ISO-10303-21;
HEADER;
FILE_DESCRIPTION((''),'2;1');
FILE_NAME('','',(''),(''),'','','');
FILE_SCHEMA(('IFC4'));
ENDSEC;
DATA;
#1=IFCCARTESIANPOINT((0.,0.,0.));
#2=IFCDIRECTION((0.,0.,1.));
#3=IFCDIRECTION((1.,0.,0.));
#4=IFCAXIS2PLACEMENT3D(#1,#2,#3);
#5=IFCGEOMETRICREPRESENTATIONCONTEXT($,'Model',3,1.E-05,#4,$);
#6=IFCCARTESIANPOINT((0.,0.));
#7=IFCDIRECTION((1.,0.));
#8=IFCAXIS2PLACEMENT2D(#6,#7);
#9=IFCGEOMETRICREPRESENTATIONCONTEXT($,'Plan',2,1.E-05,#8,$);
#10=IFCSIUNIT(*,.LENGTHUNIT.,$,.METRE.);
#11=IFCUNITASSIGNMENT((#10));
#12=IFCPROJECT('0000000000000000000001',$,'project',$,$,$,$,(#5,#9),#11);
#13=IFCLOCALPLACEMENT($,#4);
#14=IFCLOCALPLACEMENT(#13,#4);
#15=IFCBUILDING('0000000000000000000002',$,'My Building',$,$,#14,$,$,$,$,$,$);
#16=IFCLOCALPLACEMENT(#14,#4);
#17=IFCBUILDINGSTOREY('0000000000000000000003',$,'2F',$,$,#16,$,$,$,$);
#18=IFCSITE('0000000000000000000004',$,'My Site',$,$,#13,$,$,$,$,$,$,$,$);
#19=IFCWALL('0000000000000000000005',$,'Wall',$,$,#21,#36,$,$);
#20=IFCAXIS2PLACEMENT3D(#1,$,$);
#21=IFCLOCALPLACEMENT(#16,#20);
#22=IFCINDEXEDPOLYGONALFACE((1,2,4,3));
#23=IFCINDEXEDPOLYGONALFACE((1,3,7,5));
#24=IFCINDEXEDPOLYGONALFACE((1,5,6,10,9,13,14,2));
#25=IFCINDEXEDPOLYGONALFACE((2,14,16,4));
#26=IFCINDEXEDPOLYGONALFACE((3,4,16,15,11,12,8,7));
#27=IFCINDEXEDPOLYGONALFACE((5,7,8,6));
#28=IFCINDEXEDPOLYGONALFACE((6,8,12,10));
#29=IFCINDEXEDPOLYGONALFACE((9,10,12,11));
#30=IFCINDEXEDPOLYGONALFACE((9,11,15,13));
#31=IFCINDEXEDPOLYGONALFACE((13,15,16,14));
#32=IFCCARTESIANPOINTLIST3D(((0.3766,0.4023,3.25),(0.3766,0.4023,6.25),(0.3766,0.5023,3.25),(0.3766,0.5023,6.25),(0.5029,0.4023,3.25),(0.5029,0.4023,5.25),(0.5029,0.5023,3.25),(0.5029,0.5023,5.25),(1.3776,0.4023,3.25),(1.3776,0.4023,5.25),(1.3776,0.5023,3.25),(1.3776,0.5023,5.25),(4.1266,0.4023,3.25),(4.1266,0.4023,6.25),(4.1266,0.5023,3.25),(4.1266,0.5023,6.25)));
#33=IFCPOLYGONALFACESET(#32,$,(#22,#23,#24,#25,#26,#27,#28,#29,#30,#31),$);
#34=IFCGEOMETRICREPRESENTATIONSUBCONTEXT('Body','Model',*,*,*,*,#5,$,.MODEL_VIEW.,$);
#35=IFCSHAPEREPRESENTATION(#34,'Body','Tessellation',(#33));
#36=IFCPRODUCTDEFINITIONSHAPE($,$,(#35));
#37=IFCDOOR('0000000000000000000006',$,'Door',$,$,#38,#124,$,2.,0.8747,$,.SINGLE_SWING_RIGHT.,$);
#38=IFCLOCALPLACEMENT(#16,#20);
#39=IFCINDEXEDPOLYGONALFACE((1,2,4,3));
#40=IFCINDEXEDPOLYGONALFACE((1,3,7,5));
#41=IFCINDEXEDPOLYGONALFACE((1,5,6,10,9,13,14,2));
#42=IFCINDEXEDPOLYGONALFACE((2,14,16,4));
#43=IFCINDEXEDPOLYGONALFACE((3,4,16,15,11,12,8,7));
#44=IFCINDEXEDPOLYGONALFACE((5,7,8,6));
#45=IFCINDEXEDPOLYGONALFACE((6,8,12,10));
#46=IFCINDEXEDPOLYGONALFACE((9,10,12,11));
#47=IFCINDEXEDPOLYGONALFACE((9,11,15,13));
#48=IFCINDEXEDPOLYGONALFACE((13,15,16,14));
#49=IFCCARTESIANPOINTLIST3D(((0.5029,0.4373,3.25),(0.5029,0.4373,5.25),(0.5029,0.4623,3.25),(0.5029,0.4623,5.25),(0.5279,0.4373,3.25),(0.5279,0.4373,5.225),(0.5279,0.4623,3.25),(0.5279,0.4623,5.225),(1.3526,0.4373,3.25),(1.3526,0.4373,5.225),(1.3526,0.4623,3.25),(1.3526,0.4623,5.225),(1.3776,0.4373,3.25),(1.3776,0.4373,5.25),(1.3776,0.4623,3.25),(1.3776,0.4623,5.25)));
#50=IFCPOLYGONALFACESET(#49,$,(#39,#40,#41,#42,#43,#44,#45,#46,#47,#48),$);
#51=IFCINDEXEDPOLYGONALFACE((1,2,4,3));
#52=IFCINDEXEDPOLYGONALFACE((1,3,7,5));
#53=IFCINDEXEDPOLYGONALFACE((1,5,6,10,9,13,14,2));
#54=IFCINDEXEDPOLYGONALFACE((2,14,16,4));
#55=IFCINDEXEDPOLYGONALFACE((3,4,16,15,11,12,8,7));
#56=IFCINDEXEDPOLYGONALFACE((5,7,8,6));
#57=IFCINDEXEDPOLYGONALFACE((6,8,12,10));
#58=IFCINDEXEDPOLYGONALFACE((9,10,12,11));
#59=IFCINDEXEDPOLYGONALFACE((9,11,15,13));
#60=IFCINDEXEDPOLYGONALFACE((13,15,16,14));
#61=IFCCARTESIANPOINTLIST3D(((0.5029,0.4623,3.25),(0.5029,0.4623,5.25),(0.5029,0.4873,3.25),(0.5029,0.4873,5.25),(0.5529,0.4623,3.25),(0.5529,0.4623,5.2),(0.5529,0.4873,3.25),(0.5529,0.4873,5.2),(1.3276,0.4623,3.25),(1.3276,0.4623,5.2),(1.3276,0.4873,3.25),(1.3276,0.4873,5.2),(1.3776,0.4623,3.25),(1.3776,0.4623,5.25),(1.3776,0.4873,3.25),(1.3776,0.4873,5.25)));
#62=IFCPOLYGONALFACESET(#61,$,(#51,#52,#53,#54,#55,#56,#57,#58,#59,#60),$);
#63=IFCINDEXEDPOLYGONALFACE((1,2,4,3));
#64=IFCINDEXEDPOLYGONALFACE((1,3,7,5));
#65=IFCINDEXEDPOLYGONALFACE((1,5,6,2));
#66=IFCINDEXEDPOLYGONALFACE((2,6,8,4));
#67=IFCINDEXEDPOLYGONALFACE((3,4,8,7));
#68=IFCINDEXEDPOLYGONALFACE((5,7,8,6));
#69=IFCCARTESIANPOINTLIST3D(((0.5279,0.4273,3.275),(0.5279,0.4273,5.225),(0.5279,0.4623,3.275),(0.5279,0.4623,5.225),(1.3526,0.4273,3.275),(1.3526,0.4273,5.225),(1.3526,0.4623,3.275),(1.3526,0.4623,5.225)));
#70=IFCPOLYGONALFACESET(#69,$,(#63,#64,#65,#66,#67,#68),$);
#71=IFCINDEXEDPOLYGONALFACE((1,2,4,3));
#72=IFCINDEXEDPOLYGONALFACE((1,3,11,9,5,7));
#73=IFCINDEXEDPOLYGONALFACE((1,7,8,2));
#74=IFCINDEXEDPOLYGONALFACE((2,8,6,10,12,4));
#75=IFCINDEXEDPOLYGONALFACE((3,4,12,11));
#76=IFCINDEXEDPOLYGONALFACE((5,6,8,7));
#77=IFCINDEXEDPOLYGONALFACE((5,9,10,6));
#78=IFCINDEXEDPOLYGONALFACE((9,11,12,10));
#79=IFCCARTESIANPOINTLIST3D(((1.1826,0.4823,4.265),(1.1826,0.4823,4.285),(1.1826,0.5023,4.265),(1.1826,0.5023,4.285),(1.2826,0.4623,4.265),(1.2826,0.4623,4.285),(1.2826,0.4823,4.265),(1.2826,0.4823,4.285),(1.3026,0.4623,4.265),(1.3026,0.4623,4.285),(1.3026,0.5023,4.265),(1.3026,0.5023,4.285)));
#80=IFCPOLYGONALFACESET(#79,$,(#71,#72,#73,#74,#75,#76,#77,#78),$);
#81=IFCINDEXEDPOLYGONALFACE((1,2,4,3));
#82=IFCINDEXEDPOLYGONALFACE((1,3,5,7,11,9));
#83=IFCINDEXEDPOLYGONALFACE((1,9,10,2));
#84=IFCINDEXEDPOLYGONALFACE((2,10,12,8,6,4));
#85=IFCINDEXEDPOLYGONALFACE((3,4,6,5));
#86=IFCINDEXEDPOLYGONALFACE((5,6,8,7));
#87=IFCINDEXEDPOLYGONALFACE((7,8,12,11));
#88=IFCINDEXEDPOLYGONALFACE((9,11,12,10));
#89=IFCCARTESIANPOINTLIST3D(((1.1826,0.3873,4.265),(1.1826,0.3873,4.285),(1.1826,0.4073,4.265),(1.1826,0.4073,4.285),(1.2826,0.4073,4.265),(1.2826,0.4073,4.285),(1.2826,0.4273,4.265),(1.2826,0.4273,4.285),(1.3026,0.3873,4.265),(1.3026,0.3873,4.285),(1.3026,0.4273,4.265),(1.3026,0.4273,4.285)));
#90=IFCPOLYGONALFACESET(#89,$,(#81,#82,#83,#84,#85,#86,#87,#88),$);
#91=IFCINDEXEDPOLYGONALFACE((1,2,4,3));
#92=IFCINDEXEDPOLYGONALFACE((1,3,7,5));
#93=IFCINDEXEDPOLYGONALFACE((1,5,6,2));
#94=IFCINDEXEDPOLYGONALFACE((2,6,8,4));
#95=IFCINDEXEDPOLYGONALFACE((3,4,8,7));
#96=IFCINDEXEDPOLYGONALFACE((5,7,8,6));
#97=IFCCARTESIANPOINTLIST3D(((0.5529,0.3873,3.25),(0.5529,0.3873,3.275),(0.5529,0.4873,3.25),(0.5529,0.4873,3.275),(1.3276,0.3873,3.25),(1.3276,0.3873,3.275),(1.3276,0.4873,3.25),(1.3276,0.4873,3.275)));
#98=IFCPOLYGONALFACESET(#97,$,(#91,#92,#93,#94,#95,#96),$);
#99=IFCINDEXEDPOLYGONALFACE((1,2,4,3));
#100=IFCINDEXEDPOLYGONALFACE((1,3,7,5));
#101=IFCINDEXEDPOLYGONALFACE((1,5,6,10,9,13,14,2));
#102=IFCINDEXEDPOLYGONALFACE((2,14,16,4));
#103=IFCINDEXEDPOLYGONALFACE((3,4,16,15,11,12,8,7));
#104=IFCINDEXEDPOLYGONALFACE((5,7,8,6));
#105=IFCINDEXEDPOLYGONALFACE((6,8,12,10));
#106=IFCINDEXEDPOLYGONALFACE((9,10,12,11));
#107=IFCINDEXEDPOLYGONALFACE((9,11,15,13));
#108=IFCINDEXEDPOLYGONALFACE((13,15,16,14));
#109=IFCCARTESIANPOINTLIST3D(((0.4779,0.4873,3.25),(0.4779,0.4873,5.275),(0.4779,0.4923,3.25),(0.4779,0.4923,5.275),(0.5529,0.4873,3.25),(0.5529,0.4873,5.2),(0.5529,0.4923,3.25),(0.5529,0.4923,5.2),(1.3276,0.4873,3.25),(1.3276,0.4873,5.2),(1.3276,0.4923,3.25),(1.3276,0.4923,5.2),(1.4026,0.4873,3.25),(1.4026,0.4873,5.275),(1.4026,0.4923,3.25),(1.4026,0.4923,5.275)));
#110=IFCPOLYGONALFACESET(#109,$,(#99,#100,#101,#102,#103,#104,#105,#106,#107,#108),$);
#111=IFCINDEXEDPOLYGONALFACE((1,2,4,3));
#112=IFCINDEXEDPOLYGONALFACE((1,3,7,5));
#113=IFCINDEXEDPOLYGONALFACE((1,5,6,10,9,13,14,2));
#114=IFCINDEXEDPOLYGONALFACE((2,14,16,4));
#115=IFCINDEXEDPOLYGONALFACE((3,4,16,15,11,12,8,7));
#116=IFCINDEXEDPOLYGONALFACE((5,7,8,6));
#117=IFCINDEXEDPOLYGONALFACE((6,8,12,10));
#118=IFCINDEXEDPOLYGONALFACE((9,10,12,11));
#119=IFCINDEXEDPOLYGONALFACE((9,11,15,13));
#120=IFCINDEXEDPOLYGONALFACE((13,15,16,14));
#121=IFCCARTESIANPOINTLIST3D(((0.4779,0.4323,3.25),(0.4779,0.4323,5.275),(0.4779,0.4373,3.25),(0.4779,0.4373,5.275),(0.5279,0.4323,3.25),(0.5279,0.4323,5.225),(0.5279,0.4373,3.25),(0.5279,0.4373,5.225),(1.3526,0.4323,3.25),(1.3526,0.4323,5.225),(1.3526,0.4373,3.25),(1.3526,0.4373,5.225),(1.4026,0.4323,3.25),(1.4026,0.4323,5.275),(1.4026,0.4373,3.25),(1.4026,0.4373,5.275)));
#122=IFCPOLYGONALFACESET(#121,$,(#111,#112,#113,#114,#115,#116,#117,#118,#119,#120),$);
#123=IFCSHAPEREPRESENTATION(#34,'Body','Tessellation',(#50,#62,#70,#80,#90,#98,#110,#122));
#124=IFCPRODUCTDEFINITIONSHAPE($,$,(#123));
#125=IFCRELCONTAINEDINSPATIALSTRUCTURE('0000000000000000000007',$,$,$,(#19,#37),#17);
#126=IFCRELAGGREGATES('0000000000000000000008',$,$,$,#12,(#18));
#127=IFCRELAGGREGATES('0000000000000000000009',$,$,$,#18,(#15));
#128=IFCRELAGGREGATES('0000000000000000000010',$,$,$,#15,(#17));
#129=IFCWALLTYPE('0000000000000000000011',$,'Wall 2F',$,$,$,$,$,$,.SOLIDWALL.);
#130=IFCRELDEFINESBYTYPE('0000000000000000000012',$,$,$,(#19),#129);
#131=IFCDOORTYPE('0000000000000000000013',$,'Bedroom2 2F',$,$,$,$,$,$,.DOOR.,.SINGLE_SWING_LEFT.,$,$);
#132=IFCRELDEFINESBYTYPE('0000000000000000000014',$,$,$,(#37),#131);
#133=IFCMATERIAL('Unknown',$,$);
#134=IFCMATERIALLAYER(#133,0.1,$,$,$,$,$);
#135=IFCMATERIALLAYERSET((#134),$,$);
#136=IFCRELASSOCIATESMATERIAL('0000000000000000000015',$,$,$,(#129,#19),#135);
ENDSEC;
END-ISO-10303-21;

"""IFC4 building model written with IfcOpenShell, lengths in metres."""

from ifc_helpers import new_model, entity, si_unit, frame, origin_with_axes, origin_2d_with_axis, place, context, subcontext, project, spatial, line, indexed_curve, outline, extrude, shape, source, transform, mapped, material, layer, layer_set, layer_usage, type_object, type_shapes, element, fill, save


model = new_model("IFC4")

# Units and contexts
model_context = context("Model", 3, precision=1e-05, world=origin_with_axes())
plan_context = context("Plan", 2, precision=1e-05, world=origin_2d_with_axis())
body_context_1 = subcontext(model_context, "Body", "Model", "MODEL_VIEW")
body_context_2 = subcontext(plan_context, "Body", "Plan", "PLAN_VIEW")
ifc_project = project(units=[si_unit("LENGTHUNIT", "METRE")], contexts=[model_context, plan_context])

# Site, building, storey
site_placement = place(None, origin_with_axes())
site = spatial("IfcSite", under=ifc_project, at=site_placement, Name="My Site")
building_placement = place(site_placement, origin_with_axes())
building = spatial("IfcBuilding", under=site, at=building_placement, Name="My Building")
storey_placement = place(building_placement, origin_with_axes())
storey = spatial("IfcBuildingStorey", under=building, at=storey_placement, Name="2F")

# Shared definitions
ifc_material = material(Name="Unknown")

# Shared definitions
ifc_layer = layer(ifc_material, 0.1)
ifc_layer_set = layer_set([ifc_layer])
wall_type = type_object("IfcWallType", Name="Wall 2F", PredefinedType="SOLIDWALL", material=ifc_layer_set)

# Wall, opening, door
ifc_layer_usage_1 = layer_usage(ifc_layer_set, "AXIS2", "POSITIVE", 0.0)
wall_1_placement = place(storey_placement, frame((4.2266, 0.5023, 3.25), z_axis=(0.0, 0.0, 1.0), x_axis=(-1.0, 0.0, 0.0)))
wall_1 = element("IfcWall", 1, at=wall_1_placement, inside=storey, type_object=wall_type, material=ifc_layer_usage_1, Name="Wall", context=body_context_1, shape_type="SweptSolid", body=[
    extrude(outline(indexed_curve([(0.1, 0.0), (0.1, 0.1), (3.85, 0.1), (3.85, 0.0)], segments=[line(1, 2, 3, 4, 1)])), origin_with_axes(), (0.0, 0.0, 1.0), 3.0),
])
shared_shape_1 = source(origin_with_axes(), body_context_1, "Body", "SweptSolid", [
    extrude(outline(indexed_curve([(0.0, 0.0), (0.8747, 0.0), (0.8747, 2.0), (0.0, 2.0)], segments=[line(1, 2, 3, 4, 1)])), frame((0.0, -0.6, 0.0), z_axis=(0.0, -1.0, 0.0), x_axis=(1.0, 0.0, 0.0)), (0.0, 0.0, -1.0), 1.2),
])
opening_1_placement = place(wall_1_placement, frame((2.849, 0.015, 0.0), z_axis=(0.0, 0.0, 1.0), x_axis=(1.0, -0.000001, 0.0)))
opening_1 = element("IfcOpeningElement", 2, at=opening_1_placement, cuts=wall_1, PredefinedType="OPENING", context=body_context_1, shape_type="MappedRepresentation", body=[
    mapped(shared_shape_1, transform((0.0, 0.0, 0.0), x_axis=(1.0, 0.0, 0.0), y_axis=(0.0, 1.0, 0.0), z_axis=(0.0, 0.0, 1.0), scale=1.0)),
])
door_type_1 = type_object("IfcDoorType", Name="Bedroom2 2F", OperationType="SINGLE_SWING_LEFT", PredefinedType="DOOR")
shared_shape_2 = source(origin_with_axes(), body_context_1, "Body", "SweptSolid", [
    extrude(outline(indexed_curve([(0.0, 0.0), (0.0, 2.0), (0.8747, 2.0), (0.8747, 0.0), (0.8497, 0.0), (0.8497, 1.975), (0.025, 1.975), (0.025, 0.0)], segments=[line(1, 2, 3, 4, 5, 6, 7, 8, 1)])), frame((0.0, 0.025, 0.0), z_axis=(0.0, -1.0, 0.0), x_axis=(1.0, 0.0, 0.0)), (0.0, 0.0, -1.0), 0.025),
    extrude(outline(indexed_curve([(0.0, 0.0), (0.0, 2.0), (0.8747, 2.0), (0.8747, 0.0), (0.8247, 0.0), (0.8247, 1.95), (0.05, 1.95), (0.05, 0.0)], segments=[line(1, 2, 3, 4, 5, 6, 7, 8, 1)])), frame((0.0, 0.0, 0.0), z_axis=(0.0, -1.0, 0.0), x_axis=(1.0, 0.0, 0.0)), (0.0, 0.0, -1.0), 0.025),
    extrude(outline(indexed_curve([(0.0, 0.0), (0.8247, 0.0), (0.8247, 0.035), (0.0, 0.035)], segments=[line(1, 2, 3, 4, 1)])), frame((0.025, 0.025, 0.025), z_axis=(0.0, 0.0, 1.0), x_axis=(1.0, 0.0, 0.0)), (0.0, 0.0, 1.0), 1.95),
    extrude(outline(indexed_curve([(0.0, 0.0), (0.0, -0.04), (0.12, -0.04), (0.12, -0.02), (0.02, -0.02), (0.02, 0.0)], segments=[line(1, 2, 3, 4, 5, 6, 1)])), frame((0.075, 0.025, 1.015), z_axis=(0.0, 0.0, 1.0), x_axis=(1.0, 0.0, 0.0)), (0.0, 0.0, 1.0), 0.02),
    extrude(outline(indexed_curve([(0.0, 0.0), (0.0, 0.04), (0.12, 0.04), (0.12, 0.02), (0.02, 0.02), (0.02, 0.0)], segments=[line(1, 2, 3, 4, 5, 6, 1)])), frame((0.075, 0.06, 1.015), z_axis=(0.0, 0.0, 1.0), x_axis=(1.0, 0.0, 0.0)), (0.0, 0.0, 1.0), 0.02),
    extrude(outline(indexed_curve([(0.0, 0.0), (0.7747, 0.0), (0.7747, 0.1), (0.0, 0.1)], segments=[line(1, 2, 3, 4, 1)])), frame((0.05, 0.0, 0.0), z_axis=(0.0, 0.0, 1.0), x_axis=(1.0, 0.0, 0.0)), (0.0, 0.0, 1.0), 0.025),
    extrude(outline(indexed_curve([(0.0, 0.0), (0.0, 2.025), (0.9247, 2.025), (0.9247, 0.0), (0.8497, 0.0), (0.8497, 1.95), (0.075, 1.95), (0.075, 0.0)], segments=[line(1, 2, 3, 4, 5, 6, 7, 8, 1)])), frame((-0.025, -0.005, 0.0), z_axis=(0.0, -1.0, 0.0), x_axis=(1.0, 0.0, 0.0)), (0.0, 0.0, -1.0), 0.005),
    extrude(outline(indexed_curve([(0.0, 0.0), (0.0, 2.025), (0.9247, 2.025), (0.9247, 0.0), (0.8747, 0.0), (0.8747, 1.975), (0.05, 1.975), (0.05, 0.0)], segments=[line(1, 2, 3, 4, 5, 6, 7, 8, 1)])), frame((-0.025, 0.05, 0.0), z_axis=(0.0, -1.0, 0.0), x_axis=(1.0, 0.0, 0.0)), (0.0, 0.0, -1.0), 0.005),
])
shared_shape_3 = source(origin_with_axes(), body_context_2, "Body", "Curve2D", [
    entity("IfcIndexedPolyCurve", entity("IfcCartesianPointList2D", [[0.0, 0.0], [0.0, 0.05], [0.025, 0.05], [0.025, 0.025], [0.05, 0.025], [0.05, 0.0]]), [entity("IfcLineIndex", [1, 2, 3, 4, 5, 6, 1])]),
    entity("IfcIndexedPolyCurve", entity("IfcCartesianPointList2D", [[0.8747, 0.0], [0.8747, 0.05], [0.8497, 0.05], [0.8497, 0.025], [0.8247, 0.025], [0.8247, 0.0]]), [entity("IfcLineIndex", [1, 2, 3, 4, 5, 6, 1])]),
    entity("IfcTrimmedCurve", entity("IfcEllipse", entity("IfcAxis2Placement2D", entity("IfcCartesianPoint", [0.8147, 0.05]), entity("IfcDirection", [1.0, 0.0])), 0.7897, 0.8247), [entity("IfcCartesianPoint", [0.8147, 0.8747])], [entity("IfcCartesianPoint", [0.025, 0.05])], True, "CARTESIAN"),
    entity("IfcIndexedPolyCurve", entity("IfcCartesianPointList2D", [[0.8497, 0.05], [0.8147, 0.05], [0.8147, 0.8747], [0.8497, 0.8747]]), [entity("IfcLineIndex", [1, 2, 3, 4, 1])]),
])
type_shapes(door_type_1, [shared_shape_2, shared_shape_3])
door_1_placement = place(opening_1_placement, frame((0.0, 0.0, 0.0), z_axis=(0.0, 0.0, 1.0), x_axis=(1.0, 0.0, 0.0)))
door_1 = element("IfcDoor", 3, at=door_1_placement, inside=storey, type_object=door_type_1, Name="Door", OperationType="SINGLE_SWING_RIGHT", OverallHeight=2.0, OverallWidth=0.8747, shapes=[
    shape(body_context_1, "Body", "MappedRepresentation", [mapped(shared_shape_2, transform((0.0, 0.0, 0.0), x_axis=(1.0, 0.0, 0.0), y_axis=(0.0, 1.0, 0.0), z_axis=(0.0, 0.0, 1.0), scale=1.0))]),
    shape(body_context_2, "Body", "MappedRepresentation", [mapped(shared_shape_3, transform((0.0, 0.0, 0.0), x_axis=(1.0, 0.0, 0.0), y_axis=(0.0, 1.0, 0.0), z_axis=(0.0, 0.0, 1.0), scale=1.0))]),
])
fill(opening_1, door_1)

save(model, "model.ifc")
